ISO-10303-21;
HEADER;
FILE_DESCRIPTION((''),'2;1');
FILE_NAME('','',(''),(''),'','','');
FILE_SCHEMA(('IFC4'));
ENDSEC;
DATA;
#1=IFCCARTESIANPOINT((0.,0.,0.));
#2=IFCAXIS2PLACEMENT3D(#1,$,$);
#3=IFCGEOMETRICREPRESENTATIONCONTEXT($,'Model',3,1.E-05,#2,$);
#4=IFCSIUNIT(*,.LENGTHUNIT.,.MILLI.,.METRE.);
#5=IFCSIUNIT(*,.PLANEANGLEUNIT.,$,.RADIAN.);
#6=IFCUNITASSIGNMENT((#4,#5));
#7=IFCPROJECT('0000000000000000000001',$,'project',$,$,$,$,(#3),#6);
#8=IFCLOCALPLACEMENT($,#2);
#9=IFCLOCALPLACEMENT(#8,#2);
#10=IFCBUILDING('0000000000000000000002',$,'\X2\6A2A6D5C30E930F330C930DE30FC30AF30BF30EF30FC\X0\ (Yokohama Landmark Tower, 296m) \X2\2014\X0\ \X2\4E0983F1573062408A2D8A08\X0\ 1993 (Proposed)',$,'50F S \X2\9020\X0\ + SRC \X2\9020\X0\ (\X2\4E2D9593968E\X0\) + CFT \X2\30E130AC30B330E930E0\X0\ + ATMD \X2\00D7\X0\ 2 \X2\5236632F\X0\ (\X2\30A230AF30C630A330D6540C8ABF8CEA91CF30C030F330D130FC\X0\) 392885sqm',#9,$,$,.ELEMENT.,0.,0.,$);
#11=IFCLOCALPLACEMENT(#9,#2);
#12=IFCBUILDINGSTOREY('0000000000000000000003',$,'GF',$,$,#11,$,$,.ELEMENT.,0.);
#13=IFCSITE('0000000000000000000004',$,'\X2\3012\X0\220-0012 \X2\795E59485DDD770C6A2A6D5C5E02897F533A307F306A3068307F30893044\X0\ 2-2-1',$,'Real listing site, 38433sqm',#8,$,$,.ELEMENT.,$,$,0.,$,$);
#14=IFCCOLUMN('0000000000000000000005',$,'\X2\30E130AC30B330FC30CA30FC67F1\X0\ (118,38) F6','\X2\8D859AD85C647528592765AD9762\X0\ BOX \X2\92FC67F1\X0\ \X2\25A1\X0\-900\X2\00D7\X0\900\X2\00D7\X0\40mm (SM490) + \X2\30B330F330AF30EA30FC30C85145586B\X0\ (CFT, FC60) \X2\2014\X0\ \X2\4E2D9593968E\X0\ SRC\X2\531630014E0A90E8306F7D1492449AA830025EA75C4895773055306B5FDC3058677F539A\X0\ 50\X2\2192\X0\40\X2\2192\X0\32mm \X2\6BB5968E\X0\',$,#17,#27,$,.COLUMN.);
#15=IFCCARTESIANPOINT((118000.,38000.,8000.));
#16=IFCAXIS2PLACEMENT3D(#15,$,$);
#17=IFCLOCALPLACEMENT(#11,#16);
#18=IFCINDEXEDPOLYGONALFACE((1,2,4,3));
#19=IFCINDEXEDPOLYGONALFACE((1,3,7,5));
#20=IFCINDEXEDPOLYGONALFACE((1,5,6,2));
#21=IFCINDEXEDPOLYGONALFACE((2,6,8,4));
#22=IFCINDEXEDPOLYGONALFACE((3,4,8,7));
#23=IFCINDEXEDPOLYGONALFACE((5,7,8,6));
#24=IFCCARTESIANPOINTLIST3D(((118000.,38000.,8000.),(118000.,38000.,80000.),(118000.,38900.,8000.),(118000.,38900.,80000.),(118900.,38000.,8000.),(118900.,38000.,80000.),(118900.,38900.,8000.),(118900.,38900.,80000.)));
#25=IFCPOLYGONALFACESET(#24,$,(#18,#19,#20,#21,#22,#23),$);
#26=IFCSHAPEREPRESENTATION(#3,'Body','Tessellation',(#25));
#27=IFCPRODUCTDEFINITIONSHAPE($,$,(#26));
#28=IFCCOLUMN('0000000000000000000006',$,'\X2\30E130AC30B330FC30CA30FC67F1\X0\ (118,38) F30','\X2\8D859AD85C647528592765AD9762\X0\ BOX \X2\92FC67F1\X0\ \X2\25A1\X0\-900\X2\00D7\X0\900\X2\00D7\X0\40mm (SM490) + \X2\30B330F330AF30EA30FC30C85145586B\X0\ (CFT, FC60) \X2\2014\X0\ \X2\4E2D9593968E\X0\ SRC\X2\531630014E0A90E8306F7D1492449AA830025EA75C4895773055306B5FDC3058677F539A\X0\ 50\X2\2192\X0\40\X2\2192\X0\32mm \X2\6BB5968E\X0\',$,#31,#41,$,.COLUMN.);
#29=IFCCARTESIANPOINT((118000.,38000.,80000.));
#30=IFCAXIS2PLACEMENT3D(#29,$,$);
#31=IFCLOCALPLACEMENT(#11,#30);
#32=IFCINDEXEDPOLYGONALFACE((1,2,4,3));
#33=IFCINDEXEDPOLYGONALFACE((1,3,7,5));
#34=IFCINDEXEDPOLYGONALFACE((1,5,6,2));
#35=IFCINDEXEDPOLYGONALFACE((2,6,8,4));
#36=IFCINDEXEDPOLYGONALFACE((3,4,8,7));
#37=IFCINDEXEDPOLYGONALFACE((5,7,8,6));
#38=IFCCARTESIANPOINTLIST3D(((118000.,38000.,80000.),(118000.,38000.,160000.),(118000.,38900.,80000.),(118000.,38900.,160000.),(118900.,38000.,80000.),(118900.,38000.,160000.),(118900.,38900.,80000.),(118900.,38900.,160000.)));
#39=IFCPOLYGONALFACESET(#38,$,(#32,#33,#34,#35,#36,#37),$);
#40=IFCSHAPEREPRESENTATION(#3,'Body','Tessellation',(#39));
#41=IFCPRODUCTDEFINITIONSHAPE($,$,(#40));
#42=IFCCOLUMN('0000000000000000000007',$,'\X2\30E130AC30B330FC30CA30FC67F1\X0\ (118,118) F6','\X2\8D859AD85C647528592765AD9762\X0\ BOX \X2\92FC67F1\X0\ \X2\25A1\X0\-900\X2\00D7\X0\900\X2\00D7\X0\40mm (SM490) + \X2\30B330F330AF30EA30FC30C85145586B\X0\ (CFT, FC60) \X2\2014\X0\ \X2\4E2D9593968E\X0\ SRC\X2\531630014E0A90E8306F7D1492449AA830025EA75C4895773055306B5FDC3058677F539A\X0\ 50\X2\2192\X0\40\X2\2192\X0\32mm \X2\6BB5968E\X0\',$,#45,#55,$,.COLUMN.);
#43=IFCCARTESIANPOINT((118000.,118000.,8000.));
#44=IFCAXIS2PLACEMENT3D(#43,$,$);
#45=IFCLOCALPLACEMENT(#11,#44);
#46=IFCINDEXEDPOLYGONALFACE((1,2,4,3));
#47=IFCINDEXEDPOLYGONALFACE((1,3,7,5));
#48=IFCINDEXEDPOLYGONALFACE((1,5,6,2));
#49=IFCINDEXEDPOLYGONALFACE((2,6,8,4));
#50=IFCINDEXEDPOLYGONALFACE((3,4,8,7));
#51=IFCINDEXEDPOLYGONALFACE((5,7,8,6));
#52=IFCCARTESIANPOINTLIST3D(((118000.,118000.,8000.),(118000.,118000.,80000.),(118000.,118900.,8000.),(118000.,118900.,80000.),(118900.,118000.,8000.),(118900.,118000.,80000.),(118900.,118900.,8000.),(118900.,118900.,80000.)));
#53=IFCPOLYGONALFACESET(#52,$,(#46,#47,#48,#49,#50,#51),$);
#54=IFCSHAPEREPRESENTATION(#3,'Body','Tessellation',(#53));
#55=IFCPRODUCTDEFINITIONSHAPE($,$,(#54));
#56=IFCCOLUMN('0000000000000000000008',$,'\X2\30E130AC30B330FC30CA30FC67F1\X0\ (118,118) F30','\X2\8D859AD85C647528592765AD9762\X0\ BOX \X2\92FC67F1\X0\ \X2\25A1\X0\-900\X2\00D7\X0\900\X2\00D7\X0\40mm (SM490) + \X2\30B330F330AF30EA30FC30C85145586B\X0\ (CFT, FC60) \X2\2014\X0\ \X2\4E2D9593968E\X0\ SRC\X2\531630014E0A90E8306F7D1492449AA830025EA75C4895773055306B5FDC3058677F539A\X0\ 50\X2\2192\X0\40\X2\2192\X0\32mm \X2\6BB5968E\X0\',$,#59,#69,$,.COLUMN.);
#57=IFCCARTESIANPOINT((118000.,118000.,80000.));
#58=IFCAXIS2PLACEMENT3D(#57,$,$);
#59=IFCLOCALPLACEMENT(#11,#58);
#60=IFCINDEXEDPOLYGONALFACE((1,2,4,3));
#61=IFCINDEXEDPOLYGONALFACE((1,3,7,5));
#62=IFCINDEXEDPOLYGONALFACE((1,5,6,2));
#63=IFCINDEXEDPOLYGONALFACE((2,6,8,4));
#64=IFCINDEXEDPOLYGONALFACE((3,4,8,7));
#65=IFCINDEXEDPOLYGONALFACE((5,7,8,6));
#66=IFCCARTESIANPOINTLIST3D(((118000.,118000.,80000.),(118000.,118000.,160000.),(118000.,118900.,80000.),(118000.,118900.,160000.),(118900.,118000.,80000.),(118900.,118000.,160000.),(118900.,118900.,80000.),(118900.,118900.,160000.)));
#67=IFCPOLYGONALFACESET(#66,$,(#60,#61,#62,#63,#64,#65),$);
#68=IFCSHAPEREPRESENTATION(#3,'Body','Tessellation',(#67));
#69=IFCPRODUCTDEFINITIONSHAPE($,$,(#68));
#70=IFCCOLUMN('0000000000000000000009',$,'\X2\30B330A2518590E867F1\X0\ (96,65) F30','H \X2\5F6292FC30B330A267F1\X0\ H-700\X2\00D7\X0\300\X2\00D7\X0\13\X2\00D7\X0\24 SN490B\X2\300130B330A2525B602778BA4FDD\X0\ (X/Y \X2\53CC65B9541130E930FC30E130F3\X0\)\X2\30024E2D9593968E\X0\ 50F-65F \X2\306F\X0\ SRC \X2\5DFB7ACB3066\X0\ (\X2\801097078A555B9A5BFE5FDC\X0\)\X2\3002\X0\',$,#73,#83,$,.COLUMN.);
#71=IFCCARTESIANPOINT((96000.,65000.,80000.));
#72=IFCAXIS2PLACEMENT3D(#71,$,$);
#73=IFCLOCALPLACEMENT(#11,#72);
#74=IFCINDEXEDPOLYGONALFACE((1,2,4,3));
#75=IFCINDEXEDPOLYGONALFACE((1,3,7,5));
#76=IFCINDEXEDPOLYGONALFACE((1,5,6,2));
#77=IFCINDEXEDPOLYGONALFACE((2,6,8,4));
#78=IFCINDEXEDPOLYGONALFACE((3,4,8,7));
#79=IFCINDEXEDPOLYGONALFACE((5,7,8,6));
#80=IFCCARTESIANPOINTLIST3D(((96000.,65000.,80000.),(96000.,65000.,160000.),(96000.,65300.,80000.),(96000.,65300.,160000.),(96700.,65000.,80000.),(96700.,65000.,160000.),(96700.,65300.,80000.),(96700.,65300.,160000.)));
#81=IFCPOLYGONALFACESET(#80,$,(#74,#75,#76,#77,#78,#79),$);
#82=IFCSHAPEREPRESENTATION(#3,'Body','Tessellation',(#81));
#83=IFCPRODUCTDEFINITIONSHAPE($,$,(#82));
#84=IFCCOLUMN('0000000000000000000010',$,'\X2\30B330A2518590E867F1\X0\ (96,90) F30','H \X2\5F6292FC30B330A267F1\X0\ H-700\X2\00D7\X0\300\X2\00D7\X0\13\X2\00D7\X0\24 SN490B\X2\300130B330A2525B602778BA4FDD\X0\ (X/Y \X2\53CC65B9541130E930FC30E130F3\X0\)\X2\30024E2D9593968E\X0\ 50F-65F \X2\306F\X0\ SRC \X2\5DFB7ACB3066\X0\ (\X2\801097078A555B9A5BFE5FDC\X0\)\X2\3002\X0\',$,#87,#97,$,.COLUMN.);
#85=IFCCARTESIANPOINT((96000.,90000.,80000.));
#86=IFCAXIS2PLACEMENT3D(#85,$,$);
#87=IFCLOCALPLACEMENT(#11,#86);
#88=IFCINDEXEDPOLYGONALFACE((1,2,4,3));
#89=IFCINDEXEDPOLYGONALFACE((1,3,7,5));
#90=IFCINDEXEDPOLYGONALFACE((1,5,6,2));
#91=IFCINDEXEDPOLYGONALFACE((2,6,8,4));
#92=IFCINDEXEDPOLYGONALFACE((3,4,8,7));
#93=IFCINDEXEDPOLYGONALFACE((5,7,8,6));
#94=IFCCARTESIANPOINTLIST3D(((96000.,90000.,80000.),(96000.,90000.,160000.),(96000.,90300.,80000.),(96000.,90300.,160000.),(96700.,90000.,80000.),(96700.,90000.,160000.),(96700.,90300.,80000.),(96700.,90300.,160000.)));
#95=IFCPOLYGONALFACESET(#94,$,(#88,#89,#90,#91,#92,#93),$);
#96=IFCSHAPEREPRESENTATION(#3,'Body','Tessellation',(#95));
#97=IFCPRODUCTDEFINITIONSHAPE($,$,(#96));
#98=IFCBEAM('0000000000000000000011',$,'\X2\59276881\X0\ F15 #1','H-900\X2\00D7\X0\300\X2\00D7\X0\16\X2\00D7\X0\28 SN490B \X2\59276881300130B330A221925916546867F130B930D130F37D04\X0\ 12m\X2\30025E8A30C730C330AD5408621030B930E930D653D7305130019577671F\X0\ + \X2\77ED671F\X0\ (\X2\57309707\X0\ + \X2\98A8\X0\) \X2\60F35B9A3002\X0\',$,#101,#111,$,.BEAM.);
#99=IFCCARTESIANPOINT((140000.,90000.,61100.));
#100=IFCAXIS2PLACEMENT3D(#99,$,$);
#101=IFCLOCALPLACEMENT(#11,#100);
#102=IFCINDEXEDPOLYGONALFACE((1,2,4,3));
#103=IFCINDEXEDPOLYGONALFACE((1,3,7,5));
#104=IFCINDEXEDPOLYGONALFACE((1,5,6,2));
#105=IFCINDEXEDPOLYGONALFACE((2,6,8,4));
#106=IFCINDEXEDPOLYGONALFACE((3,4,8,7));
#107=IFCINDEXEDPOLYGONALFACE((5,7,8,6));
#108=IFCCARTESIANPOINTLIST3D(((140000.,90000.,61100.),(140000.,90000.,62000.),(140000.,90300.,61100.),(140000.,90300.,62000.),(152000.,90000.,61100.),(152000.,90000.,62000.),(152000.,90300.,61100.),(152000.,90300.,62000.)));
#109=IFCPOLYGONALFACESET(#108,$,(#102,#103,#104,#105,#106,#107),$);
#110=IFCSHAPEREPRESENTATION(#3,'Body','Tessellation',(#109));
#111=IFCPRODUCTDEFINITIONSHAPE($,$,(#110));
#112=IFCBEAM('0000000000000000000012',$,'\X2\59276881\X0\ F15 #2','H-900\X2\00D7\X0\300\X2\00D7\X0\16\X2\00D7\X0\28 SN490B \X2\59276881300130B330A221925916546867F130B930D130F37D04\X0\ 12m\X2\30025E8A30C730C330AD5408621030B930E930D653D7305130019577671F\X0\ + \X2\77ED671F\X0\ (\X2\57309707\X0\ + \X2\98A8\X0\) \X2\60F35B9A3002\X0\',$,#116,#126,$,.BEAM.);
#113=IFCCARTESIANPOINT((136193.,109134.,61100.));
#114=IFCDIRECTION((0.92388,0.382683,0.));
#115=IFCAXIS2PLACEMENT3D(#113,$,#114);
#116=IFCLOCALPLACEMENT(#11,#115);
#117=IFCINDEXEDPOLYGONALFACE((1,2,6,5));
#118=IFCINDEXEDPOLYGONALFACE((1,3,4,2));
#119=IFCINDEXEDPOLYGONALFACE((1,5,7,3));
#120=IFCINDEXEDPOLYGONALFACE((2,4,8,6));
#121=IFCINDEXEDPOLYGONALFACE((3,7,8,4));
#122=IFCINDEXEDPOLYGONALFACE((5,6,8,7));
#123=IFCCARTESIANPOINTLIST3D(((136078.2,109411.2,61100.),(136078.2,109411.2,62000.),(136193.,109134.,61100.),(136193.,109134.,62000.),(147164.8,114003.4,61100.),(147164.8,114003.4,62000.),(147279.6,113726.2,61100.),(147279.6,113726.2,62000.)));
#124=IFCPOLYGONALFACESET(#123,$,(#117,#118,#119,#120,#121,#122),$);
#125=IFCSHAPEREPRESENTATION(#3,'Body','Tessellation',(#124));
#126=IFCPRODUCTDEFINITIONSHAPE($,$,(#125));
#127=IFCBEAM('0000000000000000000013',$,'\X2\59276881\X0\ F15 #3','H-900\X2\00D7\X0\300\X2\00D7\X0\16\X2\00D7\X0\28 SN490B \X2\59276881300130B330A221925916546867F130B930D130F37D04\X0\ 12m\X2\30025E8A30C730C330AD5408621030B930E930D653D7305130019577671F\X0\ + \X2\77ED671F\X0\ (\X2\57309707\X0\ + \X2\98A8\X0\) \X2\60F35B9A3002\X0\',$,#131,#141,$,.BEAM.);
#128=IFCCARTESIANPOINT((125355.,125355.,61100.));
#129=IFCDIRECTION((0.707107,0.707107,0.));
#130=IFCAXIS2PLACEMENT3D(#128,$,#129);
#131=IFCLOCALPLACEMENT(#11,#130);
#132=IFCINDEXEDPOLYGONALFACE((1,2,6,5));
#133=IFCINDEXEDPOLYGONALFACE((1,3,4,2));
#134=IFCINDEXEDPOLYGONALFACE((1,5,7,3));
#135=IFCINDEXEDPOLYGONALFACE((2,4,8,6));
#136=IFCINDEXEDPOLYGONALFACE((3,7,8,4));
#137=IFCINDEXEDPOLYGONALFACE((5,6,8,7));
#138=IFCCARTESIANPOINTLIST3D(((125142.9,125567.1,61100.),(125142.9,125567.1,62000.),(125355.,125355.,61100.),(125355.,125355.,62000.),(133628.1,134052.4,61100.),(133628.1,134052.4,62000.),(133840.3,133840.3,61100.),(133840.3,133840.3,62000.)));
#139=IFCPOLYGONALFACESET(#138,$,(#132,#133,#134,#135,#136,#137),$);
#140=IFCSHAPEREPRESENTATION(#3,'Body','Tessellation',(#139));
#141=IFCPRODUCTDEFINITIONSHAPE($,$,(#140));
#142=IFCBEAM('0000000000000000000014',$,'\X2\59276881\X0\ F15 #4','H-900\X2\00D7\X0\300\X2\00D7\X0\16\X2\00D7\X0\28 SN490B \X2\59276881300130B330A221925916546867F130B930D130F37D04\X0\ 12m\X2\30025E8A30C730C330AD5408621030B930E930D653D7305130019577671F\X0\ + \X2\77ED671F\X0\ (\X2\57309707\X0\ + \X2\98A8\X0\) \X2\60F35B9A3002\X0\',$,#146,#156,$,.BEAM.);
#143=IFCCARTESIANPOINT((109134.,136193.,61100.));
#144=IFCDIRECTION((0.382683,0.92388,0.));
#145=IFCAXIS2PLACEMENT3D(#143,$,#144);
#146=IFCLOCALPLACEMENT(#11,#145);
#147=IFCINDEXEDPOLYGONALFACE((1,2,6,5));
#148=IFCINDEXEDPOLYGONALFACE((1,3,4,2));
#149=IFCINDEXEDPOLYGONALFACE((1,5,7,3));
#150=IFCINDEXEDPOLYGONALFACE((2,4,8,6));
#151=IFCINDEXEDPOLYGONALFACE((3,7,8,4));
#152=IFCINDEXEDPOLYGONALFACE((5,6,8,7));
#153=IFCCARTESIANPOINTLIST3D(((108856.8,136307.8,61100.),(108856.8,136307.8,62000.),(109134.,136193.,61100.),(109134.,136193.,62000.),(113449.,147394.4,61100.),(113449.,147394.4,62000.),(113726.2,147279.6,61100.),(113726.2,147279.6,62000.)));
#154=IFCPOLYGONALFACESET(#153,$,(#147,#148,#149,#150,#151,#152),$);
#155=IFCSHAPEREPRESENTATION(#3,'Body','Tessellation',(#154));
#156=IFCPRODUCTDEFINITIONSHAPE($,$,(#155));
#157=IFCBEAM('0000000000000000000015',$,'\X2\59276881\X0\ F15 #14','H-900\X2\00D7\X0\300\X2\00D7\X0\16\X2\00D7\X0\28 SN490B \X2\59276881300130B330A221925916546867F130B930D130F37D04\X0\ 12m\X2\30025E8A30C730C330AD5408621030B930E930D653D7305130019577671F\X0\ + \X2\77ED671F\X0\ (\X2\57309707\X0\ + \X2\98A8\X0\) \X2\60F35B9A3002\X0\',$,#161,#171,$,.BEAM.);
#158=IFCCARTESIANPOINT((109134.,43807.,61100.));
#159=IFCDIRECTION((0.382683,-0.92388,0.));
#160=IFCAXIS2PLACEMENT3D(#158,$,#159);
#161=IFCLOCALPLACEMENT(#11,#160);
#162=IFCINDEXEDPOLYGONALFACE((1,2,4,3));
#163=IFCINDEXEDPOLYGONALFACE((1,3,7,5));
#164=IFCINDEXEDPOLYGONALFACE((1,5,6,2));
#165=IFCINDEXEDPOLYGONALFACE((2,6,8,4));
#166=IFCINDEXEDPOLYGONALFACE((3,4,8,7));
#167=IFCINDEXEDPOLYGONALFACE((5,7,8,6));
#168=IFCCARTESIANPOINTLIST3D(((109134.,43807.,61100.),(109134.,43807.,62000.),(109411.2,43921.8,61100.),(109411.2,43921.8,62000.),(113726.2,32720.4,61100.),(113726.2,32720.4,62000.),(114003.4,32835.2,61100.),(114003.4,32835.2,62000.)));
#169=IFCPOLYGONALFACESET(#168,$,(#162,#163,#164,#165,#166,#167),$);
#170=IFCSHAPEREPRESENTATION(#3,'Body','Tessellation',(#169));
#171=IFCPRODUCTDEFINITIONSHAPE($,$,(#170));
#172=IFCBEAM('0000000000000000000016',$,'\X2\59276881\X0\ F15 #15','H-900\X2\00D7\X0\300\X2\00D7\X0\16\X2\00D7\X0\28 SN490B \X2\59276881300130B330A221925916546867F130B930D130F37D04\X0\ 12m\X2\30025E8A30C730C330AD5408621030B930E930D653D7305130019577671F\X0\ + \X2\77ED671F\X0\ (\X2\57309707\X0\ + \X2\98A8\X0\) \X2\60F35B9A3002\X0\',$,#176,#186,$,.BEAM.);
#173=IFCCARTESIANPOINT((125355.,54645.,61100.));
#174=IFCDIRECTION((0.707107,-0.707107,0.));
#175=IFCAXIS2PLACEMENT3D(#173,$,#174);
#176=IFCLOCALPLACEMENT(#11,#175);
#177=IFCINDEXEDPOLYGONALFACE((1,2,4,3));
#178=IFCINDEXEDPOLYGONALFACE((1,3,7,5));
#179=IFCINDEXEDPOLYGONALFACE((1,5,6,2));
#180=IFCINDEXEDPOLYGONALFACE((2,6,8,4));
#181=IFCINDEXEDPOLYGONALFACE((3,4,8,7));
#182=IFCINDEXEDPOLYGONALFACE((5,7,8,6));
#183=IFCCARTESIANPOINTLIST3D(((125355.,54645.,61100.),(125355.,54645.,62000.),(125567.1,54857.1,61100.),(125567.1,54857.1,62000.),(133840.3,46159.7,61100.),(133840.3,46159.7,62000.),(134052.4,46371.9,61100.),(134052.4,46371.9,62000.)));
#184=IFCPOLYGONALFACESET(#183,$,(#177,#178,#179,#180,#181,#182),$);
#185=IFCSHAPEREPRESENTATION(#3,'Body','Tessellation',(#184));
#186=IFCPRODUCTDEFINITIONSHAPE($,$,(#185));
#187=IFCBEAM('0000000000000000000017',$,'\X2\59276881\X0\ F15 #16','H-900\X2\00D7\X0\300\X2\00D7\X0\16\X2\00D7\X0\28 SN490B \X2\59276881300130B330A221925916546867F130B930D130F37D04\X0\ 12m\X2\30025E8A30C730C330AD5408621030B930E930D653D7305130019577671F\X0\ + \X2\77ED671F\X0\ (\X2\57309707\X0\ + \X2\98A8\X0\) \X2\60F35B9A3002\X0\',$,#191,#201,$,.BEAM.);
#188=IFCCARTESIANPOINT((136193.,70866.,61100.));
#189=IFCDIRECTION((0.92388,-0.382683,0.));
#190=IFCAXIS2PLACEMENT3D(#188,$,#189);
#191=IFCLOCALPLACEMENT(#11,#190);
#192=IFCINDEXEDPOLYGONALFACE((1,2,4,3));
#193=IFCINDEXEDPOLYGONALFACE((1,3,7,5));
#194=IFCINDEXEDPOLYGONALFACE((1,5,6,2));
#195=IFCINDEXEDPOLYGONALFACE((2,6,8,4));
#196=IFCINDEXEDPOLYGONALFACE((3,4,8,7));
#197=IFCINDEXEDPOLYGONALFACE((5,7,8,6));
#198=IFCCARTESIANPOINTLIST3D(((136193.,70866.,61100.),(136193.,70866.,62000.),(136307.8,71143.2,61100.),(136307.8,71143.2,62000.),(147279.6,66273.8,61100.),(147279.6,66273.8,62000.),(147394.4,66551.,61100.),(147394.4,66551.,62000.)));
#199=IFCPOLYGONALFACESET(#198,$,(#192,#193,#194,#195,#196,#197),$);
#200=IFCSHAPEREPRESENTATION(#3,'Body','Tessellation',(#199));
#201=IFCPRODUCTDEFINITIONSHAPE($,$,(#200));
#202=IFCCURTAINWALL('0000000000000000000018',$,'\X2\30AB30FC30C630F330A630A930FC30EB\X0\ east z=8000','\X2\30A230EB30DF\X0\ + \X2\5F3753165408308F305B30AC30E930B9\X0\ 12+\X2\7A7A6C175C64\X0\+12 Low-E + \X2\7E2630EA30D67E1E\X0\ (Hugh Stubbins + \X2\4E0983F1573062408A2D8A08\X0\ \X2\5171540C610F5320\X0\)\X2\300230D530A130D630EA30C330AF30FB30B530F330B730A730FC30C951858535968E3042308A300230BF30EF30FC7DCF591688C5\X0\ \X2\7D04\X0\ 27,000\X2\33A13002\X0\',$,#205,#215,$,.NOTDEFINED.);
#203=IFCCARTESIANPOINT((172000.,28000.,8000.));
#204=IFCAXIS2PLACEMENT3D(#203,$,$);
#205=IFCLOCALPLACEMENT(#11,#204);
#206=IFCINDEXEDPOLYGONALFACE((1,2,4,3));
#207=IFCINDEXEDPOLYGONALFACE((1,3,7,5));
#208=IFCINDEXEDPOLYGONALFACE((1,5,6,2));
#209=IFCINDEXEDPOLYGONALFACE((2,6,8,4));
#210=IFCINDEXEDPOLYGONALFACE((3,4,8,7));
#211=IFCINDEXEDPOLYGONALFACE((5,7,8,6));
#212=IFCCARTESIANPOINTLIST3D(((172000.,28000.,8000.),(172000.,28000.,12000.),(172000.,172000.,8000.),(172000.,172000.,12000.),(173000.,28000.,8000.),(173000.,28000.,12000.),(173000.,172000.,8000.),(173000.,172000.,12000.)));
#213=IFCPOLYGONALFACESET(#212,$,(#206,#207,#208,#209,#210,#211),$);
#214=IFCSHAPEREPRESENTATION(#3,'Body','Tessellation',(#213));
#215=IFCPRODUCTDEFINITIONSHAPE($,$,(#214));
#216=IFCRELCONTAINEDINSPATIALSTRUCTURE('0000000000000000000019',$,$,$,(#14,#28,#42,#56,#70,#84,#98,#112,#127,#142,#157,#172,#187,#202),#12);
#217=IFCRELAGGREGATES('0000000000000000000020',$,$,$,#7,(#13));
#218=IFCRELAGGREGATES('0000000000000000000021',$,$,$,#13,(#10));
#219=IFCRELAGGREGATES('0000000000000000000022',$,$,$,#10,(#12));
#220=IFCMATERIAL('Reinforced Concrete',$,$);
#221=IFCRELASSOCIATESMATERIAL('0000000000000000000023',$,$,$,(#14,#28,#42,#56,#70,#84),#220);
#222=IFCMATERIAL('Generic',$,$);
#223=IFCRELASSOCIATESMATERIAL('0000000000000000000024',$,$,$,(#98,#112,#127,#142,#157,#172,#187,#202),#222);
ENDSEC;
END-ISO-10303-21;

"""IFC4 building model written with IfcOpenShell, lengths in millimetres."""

from ifc_helpers import new_model, si_unit, frame, frame_2d, origin, place, context, project, spatial, rectangle, extrude, material, element, save


model = new_model("IFC4")

# Units and contexts
model_context = context("Model", 3, precision=1e-05, world=origin())
ifc_project = project(units=[si_unit("LENGTHUNIT", "METRE", prefix="MILLI"), si_unit("PLANEANGLEUNIT", "RADIAN")], contexts=[model_context])

# Site, building, storey
site_placement = place(None, origin())
site = spatial("IfcSite", under=ifc_project, at=site_placement, Name="〒220-0012 神奈川県横浜市西区みなとみらい 2-2-1", ObjectType="Real listing site, 38433sqm", CompositionType="ELEMENT", RefElevation=0.0)
building_placement = place(site_placement, origin())
building = spatial("IfcBuilding", under=site, at=building_placement, Name="横浜ランドマークタワー (Yokohama Landmark Tower, 296m) — 三菱地所設計 1993 (Proposed)", ObjectType="50F S 造 + SRC 造 (中間階) + CFT メガコラム + ATMD × 2 制振 (アクティブ同調質量ダンパー) 392885sqm", CompositionType="ELEMENT", ElevationOfRefHeight=0.0, ElevationOfTerrain=0.0)
storey_placement = place(building_placement, origin())
storey = spatial("IfcBuildingStorey", under=building, at=storey_placement, Name="GF", CompositionType="ELEMENT", Elevation=0.0)

# Columns
ifc_material_1 = material(Name="Reinforced Concrete")
column_1_placement = place(storey_placement, frame((118000.0, 38000.0, 8000.0)))
element("IfcColumn", 1, at=column_1_placement, inside=storey, material=ifc_material_1, Name="メガコーナー柱 (118,38) F6", Description="超高層用大断面 BOX 鋼柱 □-900×900×40mm (SM490) + コンクリート充填 (CFT, FC60) — 中間階 SRC化、上部は純鉄骨。座屈長さに応じ板厚 50→40→32mm 段階", PredefinedType="COLUMN", context=model_context, shape_type="SweptSolid", body=[
    extrude(rectangle(XDim=900.0, YDim=900.0, at=frame_2d((450.0, 450.0))), frame((118000.0, 38000.0, 8000.0)), (0.0, 0.0, 1.0), 72000.0),
])
column_2_placement = place(storey_placement, frame((118000.0, 38000.0, 80000.0)))
element("IfcColumn", 2, at=column_2_placement, inside=storey, material=ifc_material_1, Name="メガコーナー柱 (118,38) F30", Description="超高層用大断面 BOX 鋼柱 □-900×900×40mm (SM490) + コンクリート充填 (CFT, FC60) — 中間階 SRC化、上部は純鉄骨。座屈長さに応じ板厚 50→40→32mm 段階", PredefinedType="COLUMN", context=model_context, shape_type="SweptSolid", body=[
    extrude(rectangle(XDim=900.0, YDim=900.0, at=frame_2d((450.0, 450.0))), frame((118000.0, 38000.0, 80000.0)), (0.0, 0.0, 1.0), 80000.0),
])
column_3_placement = place(storey_placement, frame((118000.0, 118000.0, 8000.0)))
element("IfcColumn", 3, at=column_3_placement, inside=storey, material=ifc_material_1, Name="メガコーナー柱 (118,118) F6", Description="超高層用大断面 BOX 鋼柱 □-900×900×40mm (SM490) + コンクリート充填 (CFT, FC60) — 中間階 SRC化、上部は純鉄骨。座屈長さに応じ板厚 50→40→32mm 段階", PredefinedType="COLUMN", context=model_context, shape_type="SweptSolid", body=[
    extrude(rectangle(XDim=900.0, YDim=900.0, at=frame_2d((450.0, 450.0))), frame((118000.0, 118000.0, 8000.0)), (0.0, 0.0, 1.0), 72000.0),
])
column_4_placement = place(storey_placement, frame((118000.0, 118000.0, 80000.0)))
element("IfcColumn", 4, at=column_4_placement, inside=storey, material=ifc_material_1, Name="メガコーナー柱 (118,118) F30", Description="超高層用大断面 BOX 鋼柱 □-900×900×40mm (SM490) + コンクリート充填 (CFT, FC60) — 中間階 SRC化、上部は純鉄骨。座屈長さに応じ板厚 50→40→32mm 段階", PredefinedType="COLUMN", context=model_context, shape_type="SweptSolid", body=[
    extrude(rectangle(XDim=900.0, YDim=900.0, at=frame_2d((450.0, 450.0))), frame((118000.0, 118000.0, 80000.0)), (0.0, 0.0, 1.0), 80000.0),
])
column_5_placement = place(storey_placement, frame((96000.0, 65000.0, 80000.0)))
element("IfcColumn", 5, at=column_5_placement, inside=storey, material=ifc_material_1, Name="コア内部柱 (96,65) F30", Description="H 形鋼コア柱 H-700×300×13×24 SN490B、コア剛性確保 (X/Y 双方向ラーメン)。中間階 50F-65F は SRC 巻立て (耐震評定対応)。", PredefinedType="COLUMN", context=model_context, shape_type="SweptSolid", body=[
    extrude(rectangle(XDim=700.0, YDim=300.0, at=frame_2d((350.0, 150.0))), frame((96000.0, 65000.0, 80000.0)), (0.0, 0.0, 1.0), 80000.0),
])
column_6_placement = place(storey_placement, frame((96000.0, 90000.0, 80000.0)))
element("IfcColumn", 6, at=column_6_placement, inside=storey, material=ifc_material_1, Name="コア内部柱 (96,90) F30", Description="H 形鋼コア柱 H-700×300×13×24 SN490B、コア剛性確保 (X/Y 双方向ラーメン)。中間階 50F-65F は SRC 巻立て (耐震評定対応)。", PredefinedType="COLUMN", context=model_context, shape_type="SweptSolid", body=[
    extrude(rectangle(XDim=700.0, YDim=300.0, at=frame_2d((350.0, 150.0))), frame((96000.0, 90000.0, 80000.0)), (0.0, 0.0, 1.0), 80000.0),
])

# Beams
ifc_material_2 = material(Name="Generic")
beam_1_placement = place(storey_placement, frame((140000.0, 90000.0, 61100.0)))
element("IfcBeam", 7, at=beam_1_placement, inside=storey, material=ifc_material_2, Name="大梁 F15 #1", Description="H-900×300×16×28 SN490B 大梁、コア→外周柱スパン約 12m。床デッキ合成スラブ受け、長期 + 短期 (地震 + 風) 想定。", PredefinedType="BEAM", context=model_context, shape_type="SweptSolid", body=[
    extrude(rectangle(XDim=12000.0, YDim=300.0, at=frame_2d((6000.0, 150.0))), frame((140000.0, 90000.0, 61100.0)), (0.0, 0.0, 1.0), 900.0),
])
beam_2_placement = place(storey_placement, frame((136193.0, 109134.0, 61100.0), x_axis=(0.92388, 0.382683, 0.0)))
element("IfcBeam", 8, at=beam_2_placement, inside=storey, material=ifc_material_2, Name="大梁 F15 #2", Description="H-900×300×16×28 SN490B 大梁、コア→外周柱スパン約 12m。床デッキ合成スラブ受け、長期 + 短期 (地震 + 風) 想定。", PredefinedType="BEAM", context=model_context, shape_type="SweptSolid", body=[
    extrude(rectangle(XDim=12000.0, YDim=300.0, at=frame_2d((6000.0, 150.0))), frame((136193.0, 109134.0, 61100.0), x_axis=(0.92388, 0.382683, 0.0)), (0.0, 0.0, 1.0), 900.0),
])
beam_3_placement = place(storey_placement, frame((125355.0, 125355.0, 61100.0), x_axis=(0.707107, 0.707107, 0.0)))
element("IfcBeam", 9, at=beam_3_placement, inside=storey, material=ifc_material_2, Name="大梁 F15 #3", Description="H-900×300×16×28 SN490B 大梁、コア→外周柱スパン約 12m。床デッキ合成スラブ受け、長期 + 短期 (地震 + 風) 想定。", PredefinedType="BEAM", context=model_context, shape_type="SweptSolid", body=[
    extrude(rectangle(XDim=12000.0, YDim=300.0, at=frame_2d((6000.0, 150.0))), frame((125355.0, 125355.0, 61100.0), x_axis=(0.707107, 0.707107, 0.0)), (0.0, 0.0, 1.0), 900.0),
])
beam_4_placement = place(storey_placement, frame((109134.0, 136193.0, 61100.0), x_axis=(0.382683, 0.92388, 0.0)))
element("IfcBeam", 10, at=beam_4_placement, inside=storey, material=ifc_material_2, Name="大梁 F15 #4", Description="H-900×300×16×28 SN490B 大梁、コア→外周柱スパン約 12m。床デッキ合成スラブ受け、長期 + 短期 (地震 + 風) 想定。", PredefinedType="BEAM", context=model_context, shape_type="SweptSolid", body=[
    extrude(rectangle(XDim=12000.0, YDim=300.0, at=frame_2d((6000.0, 150.0))), frame((109134.0, 136193.0, 61100.0), x_axis=(0.382683, 0.92388, 0.0)), (0.0, 0.0, 1.0), 900.0),
])
beam_5_placement = place(storey_placement, frame((109134.0, 43807.0, 61100.0), x_axis=(0.382683, -0.92388, 0.0)))
element("IfcBeam", 11, at=beam_5_placement, inside=storey, material=ifc_material_2, Name="大梁 F15 #14", Description="H-900×300×16×28 SN490B 大梁、コア→外周柱スパン約 12m。床デッキ合成スラブ受け、長期 + 短期 (地震 + 風) 想定。", PredefinedType="BEAM", context=model_context, shape_type="SweptSolid", body=[
    extrude(rectangle(XDim=12000.0, YDim=300.0, at=frame_2d((6000.0, 150.0))), frame((109134.0, 43807.0, 61100.0), x_axis=(0.382683, -0.92388, 0.0)), (0.0, 0.0, 1.0), 900.0),
])
beam_6_placement = place(storey_placement, frame((125355.0, 54645.0, 61100.0), x_axis=(0.707107, -0.707107, 0.0)))
element("IfcBeam", 12, at=beam_6_placement, inside=storey, material=ifc_material_2, Name="大梁 F15 #15", Description="H-900×300×16×28 SN490B 大梁、コア→外周柱スパン約 12m。床デッキ合成スラブ受け、長期 + 短期 (地震 + 風) 想定。", PredefinedType="BEAM", context=model_context, shape_type="SweptSolid", body=[
    extrude(rectangle(XDim=12000.0, YDim=300.0, at=frame_2d((6000.0, 150.0))), frame((125355.0, 54645.0, 61100.0), x_axis=(0.707107, -0.707107, 0.0)), (0.0, 0.0, 1.0), 900.0),
])
beam_7_placement = place(storey_placement, frame((136193.0, 70866.0, 61100.0), x_axis=(0.92388, -0.382683, 0.0)))
element("IfcBeam", 13, at=beam_7_placement, inside=storey, material=ifc_material_2, Name="大梁 F15 #16", Description="H-900×300×16×28 SN490B 大梁、コア→外周柱スパン約 12m。床デッキ合成スラブ受け、長期 + 短期 (地震 + 風) 想定。", PredefinedType="BEAM", context=model_context, shape_type="SweptSolid", body=[
    extrude(rectangle(XDim=12000.0, YDim=300.0, at=frame_2d((6000.0, 150.0))), frame((136193.0, 70866.0, 61100.0), x_axis=(0.92388, -0.382683, 0.0)), (0.0, 0.0, 1.0), 900.0),
])

# Curtain wall
curtain_wall_1_placement = place(storey_placement, frame((172000.0, 28000.0, 8000.0)))
element("IfcCurtainWall", 14, at=curtain_wall_1_placement, inside=storey, material=ifc_material_2, Name="カーテンウォール east z=8000", Description="アルミ + 強化合わせガラス 12+空気層+12 Low-E + 縦リブ縞 (Hugh Stubbins + 三菱地所設計 共同意匠)。ファブリック・サンシェード内蔵階あり。タワー総外装 約 27,000㎡。", PredefinedType="NOTDEFINED", context=model_context, shape_type="SweptSolid", body=[
    extrude(rectangle(XDim=1000.0, YDim=144000.0, at=frame_2d((500.0, 72000.0))), frame((172000.0, 28000.0, 8000.0)), (0.0, 0.0, 1.0), 4000.0),
])

save(model, "model.ifc")
